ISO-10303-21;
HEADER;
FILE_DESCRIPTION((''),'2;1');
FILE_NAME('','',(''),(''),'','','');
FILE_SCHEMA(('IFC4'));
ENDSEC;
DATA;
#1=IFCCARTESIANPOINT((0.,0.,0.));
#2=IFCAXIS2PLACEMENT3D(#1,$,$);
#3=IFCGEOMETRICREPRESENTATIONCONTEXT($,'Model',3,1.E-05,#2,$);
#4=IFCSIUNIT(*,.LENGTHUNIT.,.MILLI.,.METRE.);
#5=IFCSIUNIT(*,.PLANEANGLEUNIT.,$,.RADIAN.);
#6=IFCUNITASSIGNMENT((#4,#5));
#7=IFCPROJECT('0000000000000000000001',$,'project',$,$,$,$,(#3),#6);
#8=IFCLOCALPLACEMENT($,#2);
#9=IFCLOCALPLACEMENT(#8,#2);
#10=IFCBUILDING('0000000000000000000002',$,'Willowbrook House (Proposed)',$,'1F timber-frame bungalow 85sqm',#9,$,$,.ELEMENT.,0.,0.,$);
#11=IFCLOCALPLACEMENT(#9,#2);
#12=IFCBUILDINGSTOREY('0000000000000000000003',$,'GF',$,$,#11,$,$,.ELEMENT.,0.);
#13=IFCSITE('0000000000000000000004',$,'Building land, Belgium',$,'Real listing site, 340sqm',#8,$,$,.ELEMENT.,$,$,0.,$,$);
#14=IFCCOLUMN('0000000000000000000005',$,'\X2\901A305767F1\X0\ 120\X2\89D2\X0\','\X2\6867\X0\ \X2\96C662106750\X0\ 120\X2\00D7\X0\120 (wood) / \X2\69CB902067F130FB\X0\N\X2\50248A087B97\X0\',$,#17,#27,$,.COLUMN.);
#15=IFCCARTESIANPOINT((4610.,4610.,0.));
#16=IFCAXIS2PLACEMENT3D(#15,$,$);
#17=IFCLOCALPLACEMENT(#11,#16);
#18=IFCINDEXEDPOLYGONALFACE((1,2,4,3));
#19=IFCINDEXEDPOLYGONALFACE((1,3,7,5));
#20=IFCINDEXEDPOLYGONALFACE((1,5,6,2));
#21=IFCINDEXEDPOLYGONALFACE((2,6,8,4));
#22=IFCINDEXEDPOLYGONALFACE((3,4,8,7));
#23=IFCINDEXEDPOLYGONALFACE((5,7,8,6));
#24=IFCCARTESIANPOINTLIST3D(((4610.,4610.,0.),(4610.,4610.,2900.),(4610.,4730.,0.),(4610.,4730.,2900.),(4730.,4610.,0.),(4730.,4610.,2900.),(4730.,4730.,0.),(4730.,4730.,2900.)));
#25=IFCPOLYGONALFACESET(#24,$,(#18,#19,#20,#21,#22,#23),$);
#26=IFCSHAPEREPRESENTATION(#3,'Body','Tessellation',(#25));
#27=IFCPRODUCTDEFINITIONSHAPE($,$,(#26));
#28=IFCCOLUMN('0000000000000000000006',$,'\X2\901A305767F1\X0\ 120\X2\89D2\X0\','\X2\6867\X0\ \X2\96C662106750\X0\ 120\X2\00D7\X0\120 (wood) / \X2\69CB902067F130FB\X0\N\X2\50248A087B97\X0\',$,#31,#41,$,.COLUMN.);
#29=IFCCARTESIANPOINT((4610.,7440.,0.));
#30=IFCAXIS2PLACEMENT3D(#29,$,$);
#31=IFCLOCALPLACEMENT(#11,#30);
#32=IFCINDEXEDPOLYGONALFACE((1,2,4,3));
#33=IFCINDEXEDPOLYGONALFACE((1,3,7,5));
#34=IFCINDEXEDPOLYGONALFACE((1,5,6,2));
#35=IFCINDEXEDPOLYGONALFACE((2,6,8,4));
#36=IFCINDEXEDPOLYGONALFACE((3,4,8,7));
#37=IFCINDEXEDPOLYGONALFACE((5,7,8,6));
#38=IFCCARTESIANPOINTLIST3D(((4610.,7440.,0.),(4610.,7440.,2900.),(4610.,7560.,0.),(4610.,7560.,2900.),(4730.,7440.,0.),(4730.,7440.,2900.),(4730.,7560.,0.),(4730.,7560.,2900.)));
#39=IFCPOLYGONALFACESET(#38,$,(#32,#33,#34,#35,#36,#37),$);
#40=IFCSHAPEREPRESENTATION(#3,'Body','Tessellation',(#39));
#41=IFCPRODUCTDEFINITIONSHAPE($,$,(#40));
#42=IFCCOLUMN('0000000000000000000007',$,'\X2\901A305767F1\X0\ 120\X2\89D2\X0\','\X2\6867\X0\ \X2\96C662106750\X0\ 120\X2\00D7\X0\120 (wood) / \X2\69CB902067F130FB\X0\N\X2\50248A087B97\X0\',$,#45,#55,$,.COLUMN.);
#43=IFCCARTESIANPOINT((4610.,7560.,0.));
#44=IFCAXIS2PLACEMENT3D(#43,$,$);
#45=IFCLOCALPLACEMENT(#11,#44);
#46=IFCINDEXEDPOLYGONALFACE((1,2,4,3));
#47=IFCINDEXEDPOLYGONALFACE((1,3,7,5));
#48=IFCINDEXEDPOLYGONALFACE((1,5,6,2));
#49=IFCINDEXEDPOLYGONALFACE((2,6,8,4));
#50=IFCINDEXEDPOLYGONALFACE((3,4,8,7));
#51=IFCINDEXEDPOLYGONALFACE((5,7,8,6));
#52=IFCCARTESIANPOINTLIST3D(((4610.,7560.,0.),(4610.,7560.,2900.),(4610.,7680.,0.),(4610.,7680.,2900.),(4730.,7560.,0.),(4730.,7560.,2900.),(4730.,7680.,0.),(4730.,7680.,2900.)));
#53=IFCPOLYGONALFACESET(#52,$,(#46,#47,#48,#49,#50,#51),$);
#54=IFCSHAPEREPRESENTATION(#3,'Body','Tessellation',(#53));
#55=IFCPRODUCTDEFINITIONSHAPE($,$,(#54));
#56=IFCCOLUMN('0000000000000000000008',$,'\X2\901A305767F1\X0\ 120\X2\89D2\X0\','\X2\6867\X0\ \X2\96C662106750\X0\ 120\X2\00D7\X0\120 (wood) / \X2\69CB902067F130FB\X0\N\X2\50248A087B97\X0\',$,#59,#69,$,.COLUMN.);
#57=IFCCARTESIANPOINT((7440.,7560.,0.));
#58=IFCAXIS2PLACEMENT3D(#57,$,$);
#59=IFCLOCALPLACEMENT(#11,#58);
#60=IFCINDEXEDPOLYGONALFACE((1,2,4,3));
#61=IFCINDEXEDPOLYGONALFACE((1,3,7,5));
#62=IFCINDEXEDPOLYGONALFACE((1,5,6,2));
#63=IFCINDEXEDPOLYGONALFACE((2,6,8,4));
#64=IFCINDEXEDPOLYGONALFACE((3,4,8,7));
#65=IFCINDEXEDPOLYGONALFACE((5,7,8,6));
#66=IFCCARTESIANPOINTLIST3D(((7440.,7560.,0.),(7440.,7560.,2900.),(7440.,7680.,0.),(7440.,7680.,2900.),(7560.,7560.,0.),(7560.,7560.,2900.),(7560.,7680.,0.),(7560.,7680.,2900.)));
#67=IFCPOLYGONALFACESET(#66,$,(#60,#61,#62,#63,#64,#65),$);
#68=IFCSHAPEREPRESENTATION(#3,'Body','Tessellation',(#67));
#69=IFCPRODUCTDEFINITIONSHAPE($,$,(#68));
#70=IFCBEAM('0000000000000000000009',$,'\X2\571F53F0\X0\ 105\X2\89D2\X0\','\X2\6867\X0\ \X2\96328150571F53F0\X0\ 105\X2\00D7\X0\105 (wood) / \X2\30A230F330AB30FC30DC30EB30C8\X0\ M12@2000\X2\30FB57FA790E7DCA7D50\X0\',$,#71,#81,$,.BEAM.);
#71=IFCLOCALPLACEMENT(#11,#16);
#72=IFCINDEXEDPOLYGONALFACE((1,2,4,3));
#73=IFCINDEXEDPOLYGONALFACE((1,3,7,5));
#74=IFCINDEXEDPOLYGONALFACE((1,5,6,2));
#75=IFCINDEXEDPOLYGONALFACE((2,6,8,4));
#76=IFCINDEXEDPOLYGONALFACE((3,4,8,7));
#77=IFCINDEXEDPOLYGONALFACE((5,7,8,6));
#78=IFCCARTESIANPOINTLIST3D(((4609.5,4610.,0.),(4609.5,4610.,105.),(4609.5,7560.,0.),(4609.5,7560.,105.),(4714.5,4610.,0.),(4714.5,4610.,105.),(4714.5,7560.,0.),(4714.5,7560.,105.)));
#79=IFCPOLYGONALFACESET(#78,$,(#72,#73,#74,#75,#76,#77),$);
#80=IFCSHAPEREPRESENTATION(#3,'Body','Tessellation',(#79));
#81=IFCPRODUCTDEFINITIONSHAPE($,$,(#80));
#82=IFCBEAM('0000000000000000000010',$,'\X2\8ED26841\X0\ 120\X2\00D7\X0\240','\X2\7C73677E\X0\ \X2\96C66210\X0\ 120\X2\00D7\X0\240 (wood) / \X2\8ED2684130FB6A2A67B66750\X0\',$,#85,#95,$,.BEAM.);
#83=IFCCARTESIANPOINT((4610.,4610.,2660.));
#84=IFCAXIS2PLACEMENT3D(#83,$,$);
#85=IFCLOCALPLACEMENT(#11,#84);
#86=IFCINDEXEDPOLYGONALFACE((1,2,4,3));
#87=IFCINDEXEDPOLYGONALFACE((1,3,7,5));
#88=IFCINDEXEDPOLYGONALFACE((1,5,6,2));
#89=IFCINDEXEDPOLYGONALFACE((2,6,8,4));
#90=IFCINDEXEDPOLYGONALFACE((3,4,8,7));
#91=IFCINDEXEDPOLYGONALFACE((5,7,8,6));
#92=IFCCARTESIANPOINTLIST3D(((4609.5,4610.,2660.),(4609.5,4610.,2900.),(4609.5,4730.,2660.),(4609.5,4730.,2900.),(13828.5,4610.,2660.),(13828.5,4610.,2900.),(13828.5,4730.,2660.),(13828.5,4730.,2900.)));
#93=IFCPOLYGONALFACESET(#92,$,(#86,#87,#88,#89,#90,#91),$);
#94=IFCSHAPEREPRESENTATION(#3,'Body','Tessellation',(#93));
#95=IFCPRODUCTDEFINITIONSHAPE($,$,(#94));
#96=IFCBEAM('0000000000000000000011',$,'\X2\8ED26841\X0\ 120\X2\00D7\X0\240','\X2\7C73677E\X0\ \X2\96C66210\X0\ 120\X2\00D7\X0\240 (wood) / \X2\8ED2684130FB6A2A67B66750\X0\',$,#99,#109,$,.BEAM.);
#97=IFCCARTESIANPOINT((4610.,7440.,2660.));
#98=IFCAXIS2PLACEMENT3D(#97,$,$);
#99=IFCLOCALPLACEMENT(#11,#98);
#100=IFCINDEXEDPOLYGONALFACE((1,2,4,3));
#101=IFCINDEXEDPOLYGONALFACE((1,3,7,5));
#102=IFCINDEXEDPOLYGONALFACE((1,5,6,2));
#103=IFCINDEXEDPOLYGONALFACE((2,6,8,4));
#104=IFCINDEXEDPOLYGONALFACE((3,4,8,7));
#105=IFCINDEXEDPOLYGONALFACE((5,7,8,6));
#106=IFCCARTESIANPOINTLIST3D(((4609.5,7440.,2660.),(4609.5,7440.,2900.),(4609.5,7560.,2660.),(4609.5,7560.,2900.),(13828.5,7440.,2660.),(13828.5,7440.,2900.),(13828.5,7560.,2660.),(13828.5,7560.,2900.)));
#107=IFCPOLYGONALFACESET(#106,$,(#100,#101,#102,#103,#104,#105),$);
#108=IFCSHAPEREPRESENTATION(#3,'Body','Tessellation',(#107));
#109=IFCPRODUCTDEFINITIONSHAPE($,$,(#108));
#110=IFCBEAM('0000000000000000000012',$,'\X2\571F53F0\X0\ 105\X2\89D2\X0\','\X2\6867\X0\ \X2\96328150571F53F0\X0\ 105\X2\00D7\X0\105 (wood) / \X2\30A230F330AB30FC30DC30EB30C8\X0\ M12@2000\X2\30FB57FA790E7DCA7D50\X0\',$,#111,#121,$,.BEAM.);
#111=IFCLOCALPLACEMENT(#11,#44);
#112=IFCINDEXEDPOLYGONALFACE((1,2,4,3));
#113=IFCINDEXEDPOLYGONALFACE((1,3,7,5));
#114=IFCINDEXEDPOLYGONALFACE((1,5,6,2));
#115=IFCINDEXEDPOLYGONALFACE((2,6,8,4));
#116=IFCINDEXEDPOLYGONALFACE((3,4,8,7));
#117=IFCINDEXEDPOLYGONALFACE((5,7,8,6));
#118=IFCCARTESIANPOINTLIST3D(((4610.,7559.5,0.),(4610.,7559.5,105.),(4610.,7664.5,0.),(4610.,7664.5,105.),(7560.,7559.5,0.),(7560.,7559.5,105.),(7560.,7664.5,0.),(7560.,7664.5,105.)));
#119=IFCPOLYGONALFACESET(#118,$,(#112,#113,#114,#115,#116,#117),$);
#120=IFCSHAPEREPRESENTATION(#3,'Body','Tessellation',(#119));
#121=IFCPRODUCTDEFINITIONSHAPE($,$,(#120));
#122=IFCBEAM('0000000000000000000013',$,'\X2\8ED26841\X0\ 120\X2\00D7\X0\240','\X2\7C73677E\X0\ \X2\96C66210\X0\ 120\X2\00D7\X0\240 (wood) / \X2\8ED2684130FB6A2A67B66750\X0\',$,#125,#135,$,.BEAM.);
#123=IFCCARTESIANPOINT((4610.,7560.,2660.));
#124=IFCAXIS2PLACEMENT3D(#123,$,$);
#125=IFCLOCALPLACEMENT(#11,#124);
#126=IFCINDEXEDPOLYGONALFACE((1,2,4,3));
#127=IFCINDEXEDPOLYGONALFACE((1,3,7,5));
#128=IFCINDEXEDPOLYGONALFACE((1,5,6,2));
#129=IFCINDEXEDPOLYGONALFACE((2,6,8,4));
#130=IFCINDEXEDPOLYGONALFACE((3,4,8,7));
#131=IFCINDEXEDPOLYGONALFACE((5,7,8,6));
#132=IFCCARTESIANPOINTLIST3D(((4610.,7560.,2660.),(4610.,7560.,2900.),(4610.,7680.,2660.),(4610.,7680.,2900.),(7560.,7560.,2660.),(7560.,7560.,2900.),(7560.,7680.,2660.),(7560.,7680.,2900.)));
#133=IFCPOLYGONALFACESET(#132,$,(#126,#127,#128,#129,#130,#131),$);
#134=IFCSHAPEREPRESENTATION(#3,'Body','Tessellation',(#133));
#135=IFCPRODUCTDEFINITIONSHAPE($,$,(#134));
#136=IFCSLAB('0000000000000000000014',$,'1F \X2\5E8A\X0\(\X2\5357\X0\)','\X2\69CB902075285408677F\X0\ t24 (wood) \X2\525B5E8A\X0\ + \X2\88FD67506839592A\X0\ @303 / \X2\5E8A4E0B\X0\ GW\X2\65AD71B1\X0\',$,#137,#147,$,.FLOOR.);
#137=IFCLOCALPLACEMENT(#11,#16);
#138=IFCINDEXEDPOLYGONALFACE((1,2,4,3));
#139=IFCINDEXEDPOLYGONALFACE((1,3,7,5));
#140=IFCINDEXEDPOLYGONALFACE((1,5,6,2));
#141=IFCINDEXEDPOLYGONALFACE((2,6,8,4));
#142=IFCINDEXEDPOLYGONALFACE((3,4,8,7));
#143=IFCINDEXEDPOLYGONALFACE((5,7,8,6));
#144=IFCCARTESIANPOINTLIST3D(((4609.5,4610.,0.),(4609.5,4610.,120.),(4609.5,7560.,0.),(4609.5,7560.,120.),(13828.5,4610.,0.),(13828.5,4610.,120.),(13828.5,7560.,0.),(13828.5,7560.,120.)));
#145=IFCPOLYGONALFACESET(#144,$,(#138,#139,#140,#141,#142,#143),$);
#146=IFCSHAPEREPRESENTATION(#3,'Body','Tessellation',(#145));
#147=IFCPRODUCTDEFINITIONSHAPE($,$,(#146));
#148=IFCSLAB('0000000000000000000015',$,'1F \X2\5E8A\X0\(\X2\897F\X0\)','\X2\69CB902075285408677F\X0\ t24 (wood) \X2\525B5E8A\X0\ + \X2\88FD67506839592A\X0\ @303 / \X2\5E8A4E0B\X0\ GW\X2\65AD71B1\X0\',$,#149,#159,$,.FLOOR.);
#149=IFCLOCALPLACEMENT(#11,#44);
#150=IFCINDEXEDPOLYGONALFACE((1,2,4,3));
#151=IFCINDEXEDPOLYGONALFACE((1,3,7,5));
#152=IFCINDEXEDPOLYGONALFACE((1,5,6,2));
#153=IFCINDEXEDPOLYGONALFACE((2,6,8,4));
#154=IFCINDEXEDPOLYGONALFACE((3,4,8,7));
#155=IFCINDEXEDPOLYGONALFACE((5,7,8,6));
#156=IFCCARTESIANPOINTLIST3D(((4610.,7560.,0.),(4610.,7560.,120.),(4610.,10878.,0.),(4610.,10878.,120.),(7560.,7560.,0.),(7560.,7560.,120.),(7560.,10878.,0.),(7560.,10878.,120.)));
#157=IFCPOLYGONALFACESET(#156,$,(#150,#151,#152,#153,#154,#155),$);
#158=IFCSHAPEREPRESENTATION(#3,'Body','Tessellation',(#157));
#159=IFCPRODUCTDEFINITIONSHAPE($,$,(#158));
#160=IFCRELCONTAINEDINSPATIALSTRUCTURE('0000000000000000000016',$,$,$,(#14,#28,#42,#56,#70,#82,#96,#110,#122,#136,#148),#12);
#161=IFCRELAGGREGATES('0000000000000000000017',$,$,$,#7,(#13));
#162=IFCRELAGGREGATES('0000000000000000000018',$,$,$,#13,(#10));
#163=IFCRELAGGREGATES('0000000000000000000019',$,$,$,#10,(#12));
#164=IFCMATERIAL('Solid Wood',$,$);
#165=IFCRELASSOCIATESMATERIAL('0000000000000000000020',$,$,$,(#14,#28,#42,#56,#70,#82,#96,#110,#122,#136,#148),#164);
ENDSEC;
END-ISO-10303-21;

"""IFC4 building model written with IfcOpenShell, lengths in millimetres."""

from ifc_helpers import new_model, si_unit, frame, frame_2d, origin, place, context, project, spatial, rectangle, extrude, material, element, save


model = new_model("IFC4")

# Units and contexts
model_context = context("Model", 3, precision=1e-05, world=origin())
ifc_project = project(units=[si_unit("LENGTHUNIT", "METRE", prefix="MILLI"), si_unit("PLANEANGLEUNIT", "RADIAN")], contexts=[model_context])

# Site, building, storey
site_placement = place(None, origin())
site = spatial("IfcSite", under=ifc_project, at=site_placement, Name="Building land, Belgium", ObjectType="Real listing site, 340sqm", CompositionType="ELEMENT", RefElevation=0.0)
building_placement = place(site_placement, origin())
building = spatial("IfcBuilding", under=site, at=building_placement, Name="Willowbrook House (Proposed)", ObjectType="1F timber-frame bungalow 85sqm", CompositionType="ELEMENT", ElevationOfRefHeight=0.0, ElevationOfTerrain=0.0)
storey_placement = place(building_placement, origin())
storey = spatial("IfcBuildingStorey", under=building, at=storey_placement, Name="GF", CompositionType="ELEMENT", Elevation=0.0)

# Columns
ifc_material_1 = material(Name="Solid Wood")
column_1_placement = place(storey_placement, frame((4610.0, 4610.0, 0.0)))
element("IfcColumn", 1, at=column_1_placement, inside=storey, material=ifc_material_1, Name="通し柱 120角", Description="桧 集成材 120×120 (wood) / 構造柱・N値計算", PredefinedType="COLUMN", context=model_context, shape_type="SweptSolid", body=[
    extrude(rectangle(XDim=120.0, YDim=120.0, at=frame_2d((60.0, 60.0))), frame((4610.0, 4610.0, 0.0)), (0.0, 0.0, 1.0), 2900.0),
])
column_2_placement = place(storey_placement, frame((4610.0, 7440.0, 0.0)))
element("IfcColumn", 2, at=column_2_placement, inside=storey, material=ifc_material_1, Name="通し柱 120角", Description="桧 集成材 120×120 (wood) / 構造柱・N値計算", PredefinedType="COLUMN", context=model_context, shape_type="SweptSolid", body=[
    extrude(rectangle(XDim=120.0, YDim=120.0, at=frame_2d((60.0, 60.0))), frame((4610.0, 7440.0, 0.0)), (0.0, 0.0, 1.0), 2900.0),
])
column_3_placement = place(storey_placement, frame((4610.0, 7560.0, 0.0)))
element("IfcColumn", 3, at=column_3_placement, inside=storey, material=ifc_material_1, Name="通し柱 120角", Description="桧 集成材 120×120 (wood) / 構造柱・N値計算", PredefinedType="COLUMN", context=model_context, shape_type="SweptSolid", body=[
    extrude(rectangle(XDim=120.0, YDim=120.0, at=frame_2d((60.0, 60.0))), frame((4610.0, 7560.0, 0.0)), (0.0, 0.0, 1.0), 2900.0),
])
column_4_placement = place(storey_placement, frame((7440.0, 7560.0, 0.0)))
element("IfcColumn", 4, at=column_4_placement, inside=storey, material=ifc_material_1, Name="通し柱 120角", Description="桧 集成材 120×120 (wood) / 構造柱・N値計算", PredefinedType="COLUMN", context=model_context, shape_type="SweptSolid", body=[
    extrude(rectangle(XDim=120.0, YDim=120.0, at=frame_2d((60.0, 60.0))), frame((7440.0, 7560.0, 0.0)), (0.0, 0.0, 1.0), 2900.0),
])

# Beams
beam_1_placement = place(storey_placement, frame((4610.0, 4610.0, 0.0)))
element("IfcBeam", 5, at=beam_1_placement, inside=storey, material=ifc_material_1, Name="土台 105角", Description="桧 防腐土台 105×105 (wood) / アンカーボルト M12@2000・基礎緊結", PredefinedType="BEAM", context=model_context, shape_type="SweptSolid", body=[
    extrude(rectangle(XDim=105.0, YDim=2950.0, at=frame_2d((52.0, 1475.0))), frame((4610.0, 4610.0, 0.0)), (0.0, 0.0, 1.0), 105.0),
])
beam_2_placement = place(storey_placement, frame((4610.0, 4610.0, 2660.0)))
element("IfcBeam", 6, at=beam_2_placement, inside=storey, material=ifc_material_1, Name="軒桁 120×240", Description="米松 集成 120×240 (wood) / 軒桁・横架材", PredefinedType="BEAM", context=model_context, shape_type="SweptSolid", body=[
    extrude(rectangle(XDim=9219.0, YDim=120.0, at=frame_2d((4609.0, 60.0))), frame((4610.0, 4610.0, 2660.0)), (0.0, 0.0, 1.0), 240.0),
])
beam_3_placement = place(storey_placement, frame((4610.0, 7440.0, 2660.0)))
element("IfcBeam", 7, at=beam_3_placement, inside=storey, material=ifc_material_1, Name="軒桁 120×240", Description="米松 集成 120×240 (wood) / 軒桁・横架材", PredefinedType="BEAM", context=model_context, shape_type="SweptSolid", body=[
    extrude(rectangle(XDim=9219.0, YDim=120.0, at=frame_2d((4609.0, 60.0))), frame((4610.0, 7440.0, 2660.0)), (0.0, 0.0, 1.0), 240.0),
])
beam_4_placement = place(storey_placement, frame((4610.0, 7560.0, 0.0)))
element("IfcBeam", 8, at=beam_4_placement, inside=storey, material=ifc_material_1, Name="土台 105角", Description="桧 防腐土台 105×105 (wood) / アンカーボルト M12@2000・基礎緊結", PredefinedType="BEAM", context=model_context, shape_type="SweptSolid", body=[
    extrude(rectangle(XDim=2950.0, YDim=105.0, at=frame_2d((1475.0, 52.0))), frame((4610.0, 7560.0, 0.0)), (0.0, 0.0, 1.0), 105.0),
])
beam_5_placement = place(storey_placement, frame((4610.0, 7560.0, 2660.0)))
element("IfcBeam", 9, at=beam_5_placement, inside=storey, material=ifc_material_1, Name="軒桁 120×240", Description="米松 集成 120×240 (wood) / 軒桁・横架材", PredefinedType="BEAM", context=model_context, shape_type="SweptSolid", body=[
    extrude(rectangle(XDim=2950.0, YDim=120.0, at=frame_2d((1475.0, 60.0))), frame((4610.0, 7560.0, 2660.0)), (0.0, 0.0, 1.0), 240.0),
])

# Slabs
slab_1_placement = place(storey_placement, frame((4610.0, 4610.0, 0.0)))
element("IfcSlab", 10, at=slab_1_placement, inside=storey, material=ifc_material_1, Name="1F 床(南)", Description="構造用合板 t24 (wood) 剛床 + 製材根太 @303 / 床下 GW断熱", PredefinedType="FLOOR", context=model_context, shape_type="SweptSolid", body=[
    extrude(rectangle(XDim=9219.0, YDim=2950.0, at=frame_2d((4609.0, 1475.0))), frame((4610.0, 4610.0, 0.0)), (0.0, 0.0, 1.0), 120.0),
])
slab_2_placement = place(storey_placement, frame((4610.0, 7560.0, 0.0)))
element("IfcSlab", 11, at=slab_2_placement, inside=storey, material=ifc_material_1, Name="1F 床(西)", Description="構造用合板 t24 (wood) 剛床 + 製材根太 @303 / 床下 GW断熱", PredefinedType="FLOOR", context=model_context, shape_type="SweptSolid", body=[
    extrude(rectangle(XDim=2950.0, YDim=3318.0, at=frame_2d((1475.0, 1659.0))), frame((4610.0, 7560.0, 0.0)), (0.0, 0.0, 1.0), 120.0),
])

save(model, "model.ifc")
